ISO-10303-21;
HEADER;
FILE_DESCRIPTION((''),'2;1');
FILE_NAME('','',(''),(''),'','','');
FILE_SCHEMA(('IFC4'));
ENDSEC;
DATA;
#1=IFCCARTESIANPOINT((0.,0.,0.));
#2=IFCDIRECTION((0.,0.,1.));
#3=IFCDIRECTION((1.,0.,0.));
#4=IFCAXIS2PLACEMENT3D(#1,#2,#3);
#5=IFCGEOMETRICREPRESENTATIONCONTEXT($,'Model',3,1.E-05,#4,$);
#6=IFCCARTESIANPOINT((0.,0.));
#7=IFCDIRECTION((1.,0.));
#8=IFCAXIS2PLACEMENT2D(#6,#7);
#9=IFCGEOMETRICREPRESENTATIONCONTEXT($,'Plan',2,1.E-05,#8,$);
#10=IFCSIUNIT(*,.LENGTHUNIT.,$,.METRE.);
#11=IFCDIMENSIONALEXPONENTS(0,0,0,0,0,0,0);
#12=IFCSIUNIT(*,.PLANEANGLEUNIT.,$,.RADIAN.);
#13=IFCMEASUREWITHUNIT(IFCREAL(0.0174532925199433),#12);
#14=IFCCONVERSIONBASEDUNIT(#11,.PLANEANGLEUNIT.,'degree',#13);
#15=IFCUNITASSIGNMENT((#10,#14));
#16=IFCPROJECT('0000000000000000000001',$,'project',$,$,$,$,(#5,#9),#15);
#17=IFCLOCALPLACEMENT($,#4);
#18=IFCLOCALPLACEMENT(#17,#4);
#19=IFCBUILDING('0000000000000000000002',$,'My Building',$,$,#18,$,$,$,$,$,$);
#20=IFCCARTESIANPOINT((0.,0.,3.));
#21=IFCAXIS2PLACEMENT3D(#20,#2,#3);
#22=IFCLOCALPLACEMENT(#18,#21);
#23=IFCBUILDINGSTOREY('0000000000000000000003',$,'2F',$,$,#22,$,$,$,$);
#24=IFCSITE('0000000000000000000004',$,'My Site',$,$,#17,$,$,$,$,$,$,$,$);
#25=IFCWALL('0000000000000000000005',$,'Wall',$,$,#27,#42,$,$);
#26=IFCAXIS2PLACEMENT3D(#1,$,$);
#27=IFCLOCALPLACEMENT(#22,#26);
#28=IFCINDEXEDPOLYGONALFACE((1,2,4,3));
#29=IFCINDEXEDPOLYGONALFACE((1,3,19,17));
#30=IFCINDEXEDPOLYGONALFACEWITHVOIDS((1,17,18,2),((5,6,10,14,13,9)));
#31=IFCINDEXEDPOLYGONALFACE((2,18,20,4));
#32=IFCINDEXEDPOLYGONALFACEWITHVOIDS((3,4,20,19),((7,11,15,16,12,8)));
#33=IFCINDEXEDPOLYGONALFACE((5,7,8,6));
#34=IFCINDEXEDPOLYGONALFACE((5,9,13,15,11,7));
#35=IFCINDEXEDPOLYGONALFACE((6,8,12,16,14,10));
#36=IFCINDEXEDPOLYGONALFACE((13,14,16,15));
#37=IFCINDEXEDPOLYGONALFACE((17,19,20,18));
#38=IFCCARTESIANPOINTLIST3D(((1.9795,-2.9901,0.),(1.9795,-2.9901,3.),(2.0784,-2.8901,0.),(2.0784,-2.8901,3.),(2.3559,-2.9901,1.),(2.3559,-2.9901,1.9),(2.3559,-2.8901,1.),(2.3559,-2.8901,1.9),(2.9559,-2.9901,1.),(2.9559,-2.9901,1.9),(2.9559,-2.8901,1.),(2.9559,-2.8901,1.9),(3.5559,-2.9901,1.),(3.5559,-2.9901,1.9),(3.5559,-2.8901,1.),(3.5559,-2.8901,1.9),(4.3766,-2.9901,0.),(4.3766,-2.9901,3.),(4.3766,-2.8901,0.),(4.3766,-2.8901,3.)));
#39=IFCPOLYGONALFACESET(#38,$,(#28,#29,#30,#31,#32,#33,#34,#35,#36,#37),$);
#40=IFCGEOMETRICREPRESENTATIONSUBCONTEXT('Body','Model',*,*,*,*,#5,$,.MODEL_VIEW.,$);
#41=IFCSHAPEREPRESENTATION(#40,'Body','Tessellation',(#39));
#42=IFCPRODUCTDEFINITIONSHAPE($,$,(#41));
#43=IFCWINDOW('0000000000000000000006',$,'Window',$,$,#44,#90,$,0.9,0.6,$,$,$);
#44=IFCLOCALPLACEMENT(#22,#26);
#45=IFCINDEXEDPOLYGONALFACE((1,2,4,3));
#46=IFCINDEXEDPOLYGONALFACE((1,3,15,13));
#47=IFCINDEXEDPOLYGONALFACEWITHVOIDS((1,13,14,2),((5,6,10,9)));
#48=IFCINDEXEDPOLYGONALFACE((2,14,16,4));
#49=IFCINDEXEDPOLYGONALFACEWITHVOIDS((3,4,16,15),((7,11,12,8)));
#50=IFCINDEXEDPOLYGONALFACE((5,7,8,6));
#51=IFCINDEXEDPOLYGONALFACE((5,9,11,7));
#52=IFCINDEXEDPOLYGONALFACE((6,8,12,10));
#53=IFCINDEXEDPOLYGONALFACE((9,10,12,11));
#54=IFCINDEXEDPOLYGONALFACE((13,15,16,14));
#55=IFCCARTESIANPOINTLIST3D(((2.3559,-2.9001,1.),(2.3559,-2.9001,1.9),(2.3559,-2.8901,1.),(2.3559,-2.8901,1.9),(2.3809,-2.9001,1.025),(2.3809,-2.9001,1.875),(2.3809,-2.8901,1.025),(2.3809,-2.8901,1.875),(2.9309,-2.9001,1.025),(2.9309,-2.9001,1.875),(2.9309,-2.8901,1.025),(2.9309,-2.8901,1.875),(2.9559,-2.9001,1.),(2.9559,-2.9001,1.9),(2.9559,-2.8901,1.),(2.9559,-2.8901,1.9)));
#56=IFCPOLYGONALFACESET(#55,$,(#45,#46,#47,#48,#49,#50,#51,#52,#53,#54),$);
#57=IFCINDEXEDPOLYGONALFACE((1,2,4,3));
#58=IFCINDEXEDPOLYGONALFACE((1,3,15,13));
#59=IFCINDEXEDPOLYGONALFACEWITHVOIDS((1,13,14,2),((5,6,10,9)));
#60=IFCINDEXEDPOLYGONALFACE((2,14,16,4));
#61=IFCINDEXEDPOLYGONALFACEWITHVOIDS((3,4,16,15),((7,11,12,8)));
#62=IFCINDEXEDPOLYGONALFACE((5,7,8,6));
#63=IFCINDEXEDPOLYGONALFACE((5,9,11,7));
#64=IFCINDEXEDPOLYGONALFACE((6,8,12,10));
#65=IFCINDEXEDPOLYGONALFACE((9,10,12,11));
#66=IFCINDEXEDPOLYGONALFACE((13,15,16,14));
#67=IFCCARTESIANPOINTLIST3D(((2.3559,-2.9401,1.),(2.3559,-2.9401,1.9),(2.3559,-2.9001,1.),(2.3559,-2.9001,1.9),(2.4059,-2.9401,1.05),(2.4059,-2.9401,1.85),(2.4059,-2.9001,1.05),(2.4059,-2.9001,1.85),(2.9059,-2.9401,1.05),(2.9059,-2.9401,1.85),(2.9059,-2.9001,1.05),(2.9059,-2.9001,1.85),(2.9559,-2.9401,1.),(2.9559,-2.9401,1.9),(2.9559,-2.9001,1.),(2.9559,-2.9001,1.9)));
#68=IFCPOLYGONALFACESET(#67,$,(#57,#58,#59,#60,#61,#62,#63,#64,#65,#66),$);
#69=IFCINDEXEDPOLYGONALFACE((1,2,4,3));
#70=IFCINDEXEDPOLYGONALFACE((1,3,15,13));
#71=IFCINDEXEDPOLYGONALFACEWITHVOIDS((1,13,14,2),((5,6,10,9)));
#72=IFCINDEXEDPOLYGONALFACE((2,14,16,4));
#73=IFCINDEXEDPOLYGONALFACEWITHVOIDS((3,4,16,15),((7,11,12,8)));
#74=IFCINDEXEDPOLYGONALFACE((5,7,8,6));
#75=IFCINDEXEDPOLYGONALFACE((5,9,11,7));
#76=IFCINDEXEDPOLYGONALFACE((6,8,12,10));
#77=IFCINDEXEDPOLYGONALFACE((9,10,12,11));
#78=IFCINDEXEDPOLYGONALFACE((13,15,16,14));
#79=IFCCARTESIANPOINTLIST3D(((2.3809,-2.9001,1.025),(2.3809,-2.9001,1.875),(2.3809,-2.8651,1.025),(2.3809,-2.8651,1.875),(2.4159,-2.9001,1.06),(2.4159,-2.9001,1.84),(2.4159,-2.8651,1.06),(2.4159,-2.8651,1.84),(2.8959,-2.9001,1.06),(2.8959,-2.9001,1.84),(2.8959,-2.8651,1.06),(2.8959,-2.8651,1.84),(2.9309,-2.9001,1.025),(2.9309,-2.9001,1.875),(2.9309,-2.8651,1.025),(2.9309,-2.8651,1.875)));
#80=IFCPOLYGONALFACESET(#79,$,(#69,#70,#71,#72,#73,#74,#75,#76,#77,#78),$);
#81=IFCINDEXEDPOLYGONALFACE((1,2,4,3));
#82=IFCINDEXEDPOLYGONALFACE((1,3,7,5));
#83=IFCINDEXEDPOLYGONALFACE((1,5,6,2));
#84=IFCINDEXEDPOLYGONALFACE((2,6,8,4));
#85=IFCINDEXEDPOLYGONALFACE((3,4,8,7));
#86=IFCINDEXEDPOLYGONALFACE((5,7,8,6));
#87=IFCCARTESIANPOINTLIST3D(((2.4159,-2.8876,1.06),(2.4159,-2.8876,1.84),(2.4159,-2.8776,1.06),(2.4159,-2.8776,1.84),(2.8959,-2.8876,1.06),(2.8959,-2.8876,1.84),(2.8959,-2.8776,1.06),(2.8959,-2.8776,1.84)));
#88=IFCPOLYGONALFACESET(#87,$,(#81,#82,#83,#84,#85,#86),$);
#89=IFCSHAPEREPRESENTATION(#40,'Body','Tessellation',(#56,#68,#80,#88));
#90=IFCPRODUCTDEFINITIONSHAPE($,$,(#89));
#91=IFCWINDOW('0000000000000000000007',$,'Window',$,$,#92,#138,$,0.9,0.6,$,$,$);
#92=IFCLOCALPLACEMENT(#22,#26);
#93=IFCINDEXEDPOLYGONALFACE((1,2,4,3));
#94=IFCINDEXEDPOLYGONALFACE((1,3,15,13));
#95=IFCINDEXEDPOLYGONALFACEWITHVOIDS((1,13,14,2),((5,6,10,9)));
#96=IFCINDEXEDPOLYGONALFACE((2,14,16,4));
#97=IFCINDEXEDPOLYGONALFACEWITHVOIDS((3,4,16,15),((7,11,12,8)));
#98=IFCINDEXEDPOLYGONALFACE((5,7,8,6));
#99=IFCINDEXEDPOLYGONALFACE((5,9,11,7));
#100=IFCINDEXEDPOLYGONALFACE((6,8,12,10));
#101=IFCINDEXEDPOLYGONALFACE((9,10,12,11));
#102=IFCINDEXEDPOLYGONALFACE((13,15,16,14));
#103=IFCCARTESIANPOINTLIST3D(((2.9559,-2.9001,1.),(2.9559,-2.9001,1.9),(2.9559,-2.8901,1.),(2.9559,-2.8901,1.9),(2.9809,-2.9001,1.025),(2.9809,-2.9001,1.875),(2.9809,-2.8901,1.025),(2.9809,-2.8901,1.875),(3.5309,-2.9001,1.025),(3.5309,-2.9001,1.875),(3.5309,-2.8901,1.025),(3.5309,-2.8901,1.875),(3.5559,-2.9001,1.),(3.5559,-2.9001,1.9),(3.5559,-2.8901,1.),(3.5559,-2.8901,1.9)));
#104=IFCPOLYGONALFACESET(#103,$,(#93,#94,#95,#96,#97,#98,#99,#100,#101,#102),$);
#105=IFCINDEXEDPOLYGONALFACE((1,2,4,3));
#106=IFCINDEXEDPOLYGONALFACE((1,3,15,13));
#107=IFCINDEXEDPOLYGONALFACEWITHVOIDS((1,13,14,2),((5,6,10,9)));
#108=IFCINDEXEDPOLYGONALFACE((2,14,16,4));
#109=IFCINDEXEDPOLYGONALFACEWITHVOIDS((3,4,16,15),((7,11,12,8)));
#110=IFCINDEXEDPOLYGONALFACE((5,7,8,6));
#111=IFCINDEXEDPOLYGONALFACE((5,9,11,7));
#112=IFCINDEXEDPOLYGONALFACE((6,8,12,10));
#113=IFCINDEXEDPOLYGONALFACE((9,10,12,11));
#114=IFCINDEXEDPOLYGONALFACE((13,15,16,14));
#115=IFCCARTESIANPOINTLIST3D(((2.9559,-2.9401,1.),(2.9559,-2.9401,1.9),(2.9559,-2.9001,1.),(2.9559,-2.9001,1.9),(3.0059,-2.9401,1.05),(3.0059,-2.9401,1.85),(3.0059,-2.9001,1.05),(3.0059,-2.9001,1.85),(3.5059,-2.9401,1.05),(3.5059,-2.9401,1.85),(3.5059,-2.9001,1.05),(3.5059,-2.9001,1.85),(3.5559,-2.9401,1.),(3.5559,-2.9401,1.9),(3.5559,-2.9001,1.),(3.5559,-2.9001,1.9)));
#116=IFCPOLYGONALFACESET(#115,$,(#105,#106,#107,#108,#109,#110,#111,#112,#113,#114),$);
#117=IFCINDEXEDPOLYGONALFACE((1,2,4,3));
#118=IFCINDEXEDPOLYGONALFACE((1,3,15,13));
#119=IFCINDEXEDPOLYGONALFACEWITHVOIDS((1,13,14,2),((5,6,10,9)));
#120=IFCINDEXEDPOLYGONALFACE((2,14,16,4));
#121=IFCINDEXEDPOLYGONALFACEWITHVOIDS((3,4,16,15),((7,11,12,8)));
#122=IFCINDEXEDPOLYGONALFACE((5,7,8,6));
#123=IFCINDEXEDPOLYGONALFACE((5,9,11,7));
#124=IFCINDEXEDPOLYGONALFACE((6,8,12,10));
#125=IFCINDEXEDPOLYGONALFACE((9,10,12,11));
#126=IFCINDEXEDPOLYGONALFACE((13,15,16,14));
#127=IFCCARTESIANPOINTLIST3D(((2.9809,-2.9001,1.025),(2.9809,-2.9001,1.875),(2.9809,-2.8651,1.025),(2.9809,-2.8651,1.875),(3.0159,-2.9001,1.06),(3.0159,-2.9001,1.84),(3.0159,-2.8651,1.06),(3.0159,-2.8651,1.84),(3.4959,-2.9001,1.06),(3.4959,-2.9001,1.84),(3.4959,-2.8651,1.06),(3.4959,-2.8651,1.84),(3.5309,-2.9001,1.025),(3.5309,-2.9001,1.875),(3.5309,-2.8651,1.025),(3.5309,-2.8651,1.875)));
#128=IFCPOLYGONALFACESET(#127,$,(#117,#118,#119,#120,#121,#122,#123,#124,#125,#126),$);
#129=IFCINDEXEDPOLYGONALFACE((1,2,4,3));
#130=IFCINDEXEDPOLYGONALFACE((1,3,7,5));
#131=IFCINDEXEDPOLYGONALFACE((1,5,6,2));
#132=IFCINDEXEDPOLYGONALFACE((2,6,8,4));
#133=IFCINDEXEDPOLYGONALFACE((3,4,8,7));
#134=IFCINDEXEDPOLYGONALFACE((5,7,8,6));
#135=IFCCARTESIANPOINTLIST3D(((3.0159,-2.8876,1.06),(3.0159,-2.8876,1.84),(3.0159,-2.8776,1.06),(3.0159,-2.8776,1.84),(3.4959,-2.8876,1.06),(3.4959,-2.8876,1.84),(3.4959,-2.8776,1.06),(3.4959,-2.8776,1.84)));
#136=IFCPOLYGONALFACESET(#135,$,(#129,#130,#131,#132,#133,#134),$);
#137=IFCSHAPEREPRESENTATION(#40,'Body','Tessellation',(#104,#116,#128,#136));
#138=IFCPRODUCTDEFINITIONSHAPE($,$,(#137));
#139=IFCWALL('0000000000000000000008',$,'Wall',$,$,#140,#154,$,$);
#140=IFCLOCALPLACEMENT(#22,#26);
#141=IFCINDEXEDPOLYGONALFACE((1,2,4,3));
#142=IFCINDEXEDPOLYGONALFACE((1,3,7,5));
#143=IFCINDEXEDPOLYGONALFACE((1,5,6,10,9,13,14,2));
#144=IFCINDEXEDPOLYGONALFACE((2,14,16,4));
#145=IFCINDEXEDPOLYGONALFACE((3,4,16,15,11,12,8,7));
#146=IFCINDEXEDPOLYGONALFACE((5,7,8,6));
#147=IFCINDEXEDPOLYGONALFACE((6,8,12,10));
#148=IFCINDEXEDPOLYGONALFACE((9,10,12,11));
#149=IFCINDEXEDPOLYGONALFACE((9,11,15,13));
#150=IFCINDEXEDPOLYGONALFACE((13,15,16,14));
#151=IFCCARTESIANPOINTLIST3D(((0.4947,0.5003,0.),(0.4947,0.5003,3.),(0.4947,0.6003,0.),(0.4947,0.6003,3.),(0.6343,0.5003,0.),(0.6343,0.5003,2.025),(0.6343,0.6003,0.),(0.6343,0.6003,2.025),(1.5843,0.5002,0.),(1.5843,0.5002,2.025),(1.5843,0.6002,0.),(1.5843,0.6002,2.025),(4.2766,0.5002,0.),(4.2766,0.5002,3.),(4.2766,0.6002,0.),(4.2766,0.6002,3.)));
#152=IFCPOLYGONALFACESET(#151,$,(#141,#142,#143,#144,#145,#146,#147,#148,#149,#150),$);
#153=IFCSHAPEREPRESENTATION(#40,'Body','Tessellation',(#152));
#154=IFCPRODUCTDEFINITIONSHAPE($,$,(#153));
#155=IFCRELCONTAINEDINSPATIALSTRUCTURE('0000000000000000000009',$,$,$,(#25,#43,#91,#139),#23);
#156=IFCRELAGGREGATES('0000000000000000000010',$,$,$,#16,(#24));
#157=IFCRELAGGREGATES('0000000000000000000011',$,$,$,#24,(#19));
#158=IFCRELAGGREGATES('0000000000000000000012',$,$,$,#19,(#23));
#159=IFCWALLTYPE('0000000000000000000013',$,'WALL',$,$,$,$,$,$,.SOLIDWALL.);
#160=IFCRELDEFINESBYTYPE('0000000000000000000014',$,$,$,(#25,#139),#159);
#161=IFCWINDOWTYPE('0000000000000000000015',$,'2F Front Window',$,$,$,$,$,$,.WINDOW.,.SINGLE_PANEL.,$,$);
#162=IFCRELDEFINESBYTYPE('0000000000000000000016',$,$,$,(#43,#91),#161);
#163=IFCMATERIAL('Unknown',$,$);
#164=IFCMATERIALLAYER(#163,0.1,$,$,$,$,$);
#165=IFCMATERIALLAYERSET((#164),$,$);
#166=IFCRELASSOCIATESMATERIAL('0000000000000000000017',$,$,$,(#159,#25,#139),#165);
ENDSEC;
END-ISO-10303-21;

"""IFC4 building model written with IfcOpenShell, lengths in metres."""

from ifc_helpers import new_model, entity, si_unit, converted_unit, frame, origin_with_axes, origin_2d_with_axis, place, context, subcontext, project, spatial, line, indexed_curve, outline, extrude, shape, source, transform, mapped, material, layer, layer_set, layer_usage, type_object, type_shapes, element, fill, save


model = new_model("IFC4")

# Units and contexts
model_context = context("Model", 3, precision=1e-05, world=origin_with_axes())
plan_context = context("Plan", 2, precision=1e-05, world=origin_2d_with_axis())
body_context_1 = subcontext(model_context, "Body", "Model", "MODEL_VIEW")
body_context_2 = subcontext(plan_context, "Body", "Plan", "PLAN_VIEW")
ifc_project = project(units=[si_unit("LENGTHUNIT", "METRE"), converted_unit("PLANEANGLEUNIT", "degree", entity("IfcReal", 0.0174532925199433), si_unit("PLANEANGLEUNIT", "RADIAN"), dimensions=[0, 0, 0, 0, 0, 0, 0])], contexts=[model_context, plan_context])

# Site, building, storey
site_placement = place(None, origin_with_axes())
site = spatial("IfcSite", under=ifc_project, at=site_placement, Name="My Site")
building_placement = place(site_placement, origin_with_axes())
building = spatial("IfcBuilding", under=site, at=building_placement, Name="My Building")
storey_placement = place(building_placement, frame((0.0, 0.0, 3.0), z_axis=(0.0, 0.0, 1.0), x_axis=(1.0, 0.0, 0.0)))
storey = spatial("IfcBuildingStorey", under=building, at=storey_placement, Name="2F")

# Shared definitions
ifc_material = material(Name="Unknown")

# Shared definitions
ifc_layer = layer(ifc_material, 0.1)
ifc_layer_set = layer_set([ifc_layer])
wall_type = type_object("IfcWallType", Name="WALL", PredefinedType="SOLIDWALL", material=ifc_layer_set)

# Wall, openings, windows
ifc_layer_usage_1 = layer_usage(ifc_layer_set, "AXIS2", "POSITIVE", 0.0)
wall_1_placement = place(storey_placement, frame((1.9795, -2.9901, 0.0), z_axis=(0.0, 0.0, 1.0), x_axis=(1.0, 0.0, 0.0)))
wall_1 = element("IfcWall", 1, at=wall_1_placement, inside=storey, type_object=wall_type, material=ifc_layer_usage_1, Name="Wall", context=body_context_1, shape_type="SweptSolid", body=[
    extrude(outline(indexed_curve([(0.0, 0.0), (0.0989, 0.1), (2.3971, 0.1), (2.3971, 0.0)], segments=[line(1, 2, 3, 4, 1)])), origin_with_axes(), (0.0, 0.0, 1.0), 3.0),
])
shared_shape_1 = source(origin_with_axes(), body_context_1, "Body", "SweptSolid", [
    extrude(outline(indexed_curve([(0.0, 0.0), (0.6, 0.0), (0.6, 0.9), (0.0, 0.9)], segments=[line(1, 2, 3, 4, 1)])), frame((0.0, -0.6, 0.0), z_axis=(0.0, -1.0, 0.0), x_axis=(1.0, 0.0, 0.0)), (0.0, 0.0, -1.0), 1.2),
])
opening_1_placement = place(wall_1_placement, frame((0.3764, 0.0, 1.0), z_axis=(0.0, 0.0, 1.0), x_axis=(1.0, 0.0, 0.0)))
opening_1 = element("IfcOpeningElement", 2, at=opening_1_placement, cuts=wall_1, PredefinedType="OPENING", context=body_context_1, shape_type="MappedRepresentation", body=[
    mapped(shared_shape_1, transform((0.0, 0.0, 0.0), x_axis=(1.0, 0.0, 0.0), y_axis=(0.0, 1.0, 0.0), z_axis=(0.0, 0.0, 1.0), scale=1.0)),
])
opening_2_placement = place(wall_1_placement, frame((0.9764, 0.0, 1.0), z_axis=(0.0, 0.0, 1.0), x_axis=(1.0, 0.0, 0.0)))
opening_2 = element("IfcOpeningElement", 3, at=opening_2_placement, cuts=wall_1, PredefinedType="OPENING", context=body_context_1, shape_type="MappedRepresentation", body=[
    mapped(shared_shape_1, transform((0.0, 0.0, 0.0), x_axis=(1.0, 0.0, 0.0), y_axis=(0.0, 1.0, 0.0), z_axis=(0.0, 0.0, 1.0), scale=1.0)),
])
window_type = type_object("IfcWindowType", Name="2F Front Window", PartitioningType="SINGLE_PANEL", PredefinedType="WINDOW")
shared_shape_2 = source(origin_with_axes(), body_context_1, "Body", "SweptSolid", [
    extrude(outline(indexed_curve([(0.0, 0.0), (0.6, 0.0), (0.6, 0.9), (0.0, 0.9)], segments=[line(1, 2, 3, 4, 1)]), holes=[indexed_curve([(0.025, 0.025), (0.575, 0.025), (0.575, 0.875), (0.025, 0.875)], segments=[line(1, 2, 3, 4, 1)])]), frame((0.0, 0.09, 0.0), z_axis=(0.0, -1.0, 0.0), x_axis=(1.0, 0.0, 0.0)), (0.0, 0.0, -1.0), 0.01),
    extrude(outline(indexed_curve([(0.0, 0.0), (0.6, 0.0), (0.6, 0.9), (0.0, 0.9)], segments=[line(1, 2, 3, 4, 1)]), holes=[indexed_curve([(0.05, 0.05), (0.55, 0.05), (0.55, 0.85), (0.05, 0.85)], segments=[line(1, 2, 3, 4, 1)])]), frame((0.0, 0.05, 0.0), z_axis=(0.0, -1.0, 0.0), x_axis=(1.0, 0.0, 0.0)), (0.0, 0.0, -1.0), 0.04),
    extrude(outline(indexed_curve([(0.0, 0.0), (0.55, 0.0), (0.55, 0.85), (0.0, 0.85)], segments=[line(1, 2, 3, 4, 1)]), holes=[indexed_curve([(0.035, 0.035), (0.515, 0.035), (0.515, 0.815), (0.035, 0.815)], segments=[line(1, 2, 3, 4, 1)])]), frame((0.025, 0.09, 0.025), z_axis=(0.0, -1.0, 0.0), x_axis=(1.0, 0.0, 0.0)), (0.0, 0.0, -1.0), 0.035),
    extrude(outline(indexed_curve([(0.035, 0.035), (0.515, 0.035), (0.515, 0.815), (0.035, 0.815)], segments=[line(1, 2, 3, 4, 1)])), frame((0.025, 0.1025, 0.025), z_axis=(0.0, -1.0, 0.0), x_axis=(1.0, 0.0, 0.0)), (0.0, 0.0, -1.0), 0.01),
])
shared_shape_3 = source(origin_with_axes(), body_context_2, "Body", "Curve2D", [
    entity("IfcIndexedPolyCurve", entity("IfcCartesianPointList2D", [[0.05, 0.05], [0.55, 0.05]])),
    entity("IfcIndexedPolyCurve", entity("IfcCartesianPointList2D", [[0.0, 0.1], [0.025, 0.1], [0.025, 0.09], [0.05, 0.09], [0.05, 0.05], [0.0, 0.05]]), [entity("IfcLineIndex", [1, 2, 3, 4, 5, 6, 1])]),
    entity("IfcIndexedPolyCurve", entity("IfcCartesianPointList2D", [[0.6, 0.1], [0.575, 0.1], [0.575, 0.09], [0.55, 0.09], [0.55, 0.05], [0.6, 0.05]]), [entity("IfcLineIndex", [1, 2, 3, 4, 5, 6, 1])]),
    entity("IfcIndexedPolyCurve", entity("IfcCartesianPointList2D", [[0.025, 0.09], [0.06, 0.09], [0.06, 0.125], [0.025, 0.125]]), [entity("IfcLineIndex", [1, 2, 3, 4, 1])]),
    entity("IfcIndexedPolyCurve", entity("IfcCartesianPointList2D", [[0.575, 0.09], [0.54, 0.09], [0.54, 0.125], [0.575, 0.125]]), [entity("IfcLineIndex", [1, 2, 3, 4, 1])]),
    entity("IfcIndexedPolyCurve", entity("IfcCartesianPointList2D", [[0.06, 0.09], [0.54, 0.09]])),
    entity("IfcIndexedPolyCurve", entity("IfcCartesianPointList2D", [[0.06, 0.125], [0.54, 0.125]])),
    entity("IfcIndexedPolyCurve", entity("IfcCartesianPointList2D", [[0.06, 0.1075], [0.54, 0.1075]])),
])
type_shapes(window_type, [shared_shape_2, shared_shape_3])
window_1_placement = place(opening_1_placement, frame((0.0, 0.0, 0.0), z_axis=(0.0, 0.0, 1.0), x_axis=(1.0, 0.0, 0.0)))
window_1 = element("IfcWindow", 4, at=window_1_placement, inside=storey, type_object=window_type, Name="Window", OverallHeight=0.9, OverallWidth=0.6, shapes=[
    shape(body_context_1, "Body", "MappedRepresentation", [mapped(shared_shape_2, transform((0.0, 0.0, 0.0), x_axis=(1.0, 0.0, 0.0), y_axis=(0.0, 1.0, 0.0), z_axis=(0.0, 0.0, 1.0), scale=1.0))]),
    shape(body_context_2, "Body", "MappedRepresentation", [mapped(shared_shape_3, transform((0.0, 0.0, 0.0), x_axis=(1.0, 0.0, 0.0), y_axis=(0.0, 1.0, 0.0), z_axis=(0.0, 0.0, 1.0), scale=1.0))]),
])
fill(opening_1, window_1)
window_2_placement = place(opening_2_placement, frame((0.0, 0.0, 0.0), z_axis=(0.0, 0.0, 1.0), x_axis=(1.0, 0.0, 0.0)))
window_2 = element("IfcWindow", 5, at=window_2_placement, inside=storey, type_object=window_type, Name="Window", OverallHeight=0.9, OverallWidth=0.6, shapes=[
    shape(body_context_1, "Body", "MappedRepresentation", [mapped(shared_shape_2, transform((0.0, 0.0, 0.0), x_axis=(1.0, 0.0, 0.0), y_axis=(0.0, 1.0, 0.0), z_axis=(0.0, 0.0, 1.0), scale=1.0))]),
    shape(body_context_2, "Body", "MappedRepresentation", [mapped(shared_shape_3, transform((0.0, 0.0, 0.0), x_axis=(1.0, 0.0, 0.0), y_axis=(0.0, 1.0, 0.0), z_axis=(0.0, 0.0, 1.0), scale=1.0))]),
])
fill(opening_2, window_2)

# Wall, opening
ifc_layer_usage_2 = layer_usage(ifc_layer_set, "AXIS2", "POSITIVE", 0.0)
wall_2_placement = place(storey_placement, frame((4.2766, 0.6002, 0.0), z_axis=(0.0, 0.0, 1.0), x_axis=(-1.0, 0.000024, 0.0)))
wall_2 = element("IfcWall", 6, at=wall_2_placement, inside=storey, type_object=wall_type, material=ifc_layer_usage_2, Name="Wall", context=body_context_1, shape_type="SweptSolid", body=[
    extrude(outline(indexed_curve([(0.0, 0.0), (0.0, 0.1), (3.782, 0.1), (3.782, 0.0)], segments=[line(1, 2, 3, 4, 1)])), origin_with_axes(), (0.0, 0.0, 1.0), 3.0),
])
shared_shape_4 = source(origin_with_axes(), body_context_1, "Body", "SweptSolid", [
    extrude(outline(indexed_curve([(0.0, 0.0), (0.95, 0.0), (0.95, 2.025), (0.0, 2.025)], segments=[line(1, 2, 3, 4, 1)])), frame((-0.025, -0.6, 0.0), z_axis=(0.0, -1.0, 0.0), x_axis=(1.0, 0.0, 0.0)), (0.0, 0.0, -1.0), 1.2),
])
opening_3_placement = place(wall_2_placement, frame((2.7173, 0.0, 0.0), z_axis=(0.0, 0.0, 1.0), x_axis=(1.0, 0.0, 0.0)))
element("IfcOpeningElement", 7, at=opening_3_placement, cuts=wall_2, PredefinedType="OPENING", context=body_context_1, shape_type="MappedRepresentation", body=[
    mapped(shared_shape_4, transform((0.0, 0.0, 0.0), x_axis=(1.0, 0.0, 0.0), y_axis=(0.0, 1.0, 0.0), z_axis=(0.0, 0.0, 1.0), scale=1.0)),
])

save(model, "model.ifc")
